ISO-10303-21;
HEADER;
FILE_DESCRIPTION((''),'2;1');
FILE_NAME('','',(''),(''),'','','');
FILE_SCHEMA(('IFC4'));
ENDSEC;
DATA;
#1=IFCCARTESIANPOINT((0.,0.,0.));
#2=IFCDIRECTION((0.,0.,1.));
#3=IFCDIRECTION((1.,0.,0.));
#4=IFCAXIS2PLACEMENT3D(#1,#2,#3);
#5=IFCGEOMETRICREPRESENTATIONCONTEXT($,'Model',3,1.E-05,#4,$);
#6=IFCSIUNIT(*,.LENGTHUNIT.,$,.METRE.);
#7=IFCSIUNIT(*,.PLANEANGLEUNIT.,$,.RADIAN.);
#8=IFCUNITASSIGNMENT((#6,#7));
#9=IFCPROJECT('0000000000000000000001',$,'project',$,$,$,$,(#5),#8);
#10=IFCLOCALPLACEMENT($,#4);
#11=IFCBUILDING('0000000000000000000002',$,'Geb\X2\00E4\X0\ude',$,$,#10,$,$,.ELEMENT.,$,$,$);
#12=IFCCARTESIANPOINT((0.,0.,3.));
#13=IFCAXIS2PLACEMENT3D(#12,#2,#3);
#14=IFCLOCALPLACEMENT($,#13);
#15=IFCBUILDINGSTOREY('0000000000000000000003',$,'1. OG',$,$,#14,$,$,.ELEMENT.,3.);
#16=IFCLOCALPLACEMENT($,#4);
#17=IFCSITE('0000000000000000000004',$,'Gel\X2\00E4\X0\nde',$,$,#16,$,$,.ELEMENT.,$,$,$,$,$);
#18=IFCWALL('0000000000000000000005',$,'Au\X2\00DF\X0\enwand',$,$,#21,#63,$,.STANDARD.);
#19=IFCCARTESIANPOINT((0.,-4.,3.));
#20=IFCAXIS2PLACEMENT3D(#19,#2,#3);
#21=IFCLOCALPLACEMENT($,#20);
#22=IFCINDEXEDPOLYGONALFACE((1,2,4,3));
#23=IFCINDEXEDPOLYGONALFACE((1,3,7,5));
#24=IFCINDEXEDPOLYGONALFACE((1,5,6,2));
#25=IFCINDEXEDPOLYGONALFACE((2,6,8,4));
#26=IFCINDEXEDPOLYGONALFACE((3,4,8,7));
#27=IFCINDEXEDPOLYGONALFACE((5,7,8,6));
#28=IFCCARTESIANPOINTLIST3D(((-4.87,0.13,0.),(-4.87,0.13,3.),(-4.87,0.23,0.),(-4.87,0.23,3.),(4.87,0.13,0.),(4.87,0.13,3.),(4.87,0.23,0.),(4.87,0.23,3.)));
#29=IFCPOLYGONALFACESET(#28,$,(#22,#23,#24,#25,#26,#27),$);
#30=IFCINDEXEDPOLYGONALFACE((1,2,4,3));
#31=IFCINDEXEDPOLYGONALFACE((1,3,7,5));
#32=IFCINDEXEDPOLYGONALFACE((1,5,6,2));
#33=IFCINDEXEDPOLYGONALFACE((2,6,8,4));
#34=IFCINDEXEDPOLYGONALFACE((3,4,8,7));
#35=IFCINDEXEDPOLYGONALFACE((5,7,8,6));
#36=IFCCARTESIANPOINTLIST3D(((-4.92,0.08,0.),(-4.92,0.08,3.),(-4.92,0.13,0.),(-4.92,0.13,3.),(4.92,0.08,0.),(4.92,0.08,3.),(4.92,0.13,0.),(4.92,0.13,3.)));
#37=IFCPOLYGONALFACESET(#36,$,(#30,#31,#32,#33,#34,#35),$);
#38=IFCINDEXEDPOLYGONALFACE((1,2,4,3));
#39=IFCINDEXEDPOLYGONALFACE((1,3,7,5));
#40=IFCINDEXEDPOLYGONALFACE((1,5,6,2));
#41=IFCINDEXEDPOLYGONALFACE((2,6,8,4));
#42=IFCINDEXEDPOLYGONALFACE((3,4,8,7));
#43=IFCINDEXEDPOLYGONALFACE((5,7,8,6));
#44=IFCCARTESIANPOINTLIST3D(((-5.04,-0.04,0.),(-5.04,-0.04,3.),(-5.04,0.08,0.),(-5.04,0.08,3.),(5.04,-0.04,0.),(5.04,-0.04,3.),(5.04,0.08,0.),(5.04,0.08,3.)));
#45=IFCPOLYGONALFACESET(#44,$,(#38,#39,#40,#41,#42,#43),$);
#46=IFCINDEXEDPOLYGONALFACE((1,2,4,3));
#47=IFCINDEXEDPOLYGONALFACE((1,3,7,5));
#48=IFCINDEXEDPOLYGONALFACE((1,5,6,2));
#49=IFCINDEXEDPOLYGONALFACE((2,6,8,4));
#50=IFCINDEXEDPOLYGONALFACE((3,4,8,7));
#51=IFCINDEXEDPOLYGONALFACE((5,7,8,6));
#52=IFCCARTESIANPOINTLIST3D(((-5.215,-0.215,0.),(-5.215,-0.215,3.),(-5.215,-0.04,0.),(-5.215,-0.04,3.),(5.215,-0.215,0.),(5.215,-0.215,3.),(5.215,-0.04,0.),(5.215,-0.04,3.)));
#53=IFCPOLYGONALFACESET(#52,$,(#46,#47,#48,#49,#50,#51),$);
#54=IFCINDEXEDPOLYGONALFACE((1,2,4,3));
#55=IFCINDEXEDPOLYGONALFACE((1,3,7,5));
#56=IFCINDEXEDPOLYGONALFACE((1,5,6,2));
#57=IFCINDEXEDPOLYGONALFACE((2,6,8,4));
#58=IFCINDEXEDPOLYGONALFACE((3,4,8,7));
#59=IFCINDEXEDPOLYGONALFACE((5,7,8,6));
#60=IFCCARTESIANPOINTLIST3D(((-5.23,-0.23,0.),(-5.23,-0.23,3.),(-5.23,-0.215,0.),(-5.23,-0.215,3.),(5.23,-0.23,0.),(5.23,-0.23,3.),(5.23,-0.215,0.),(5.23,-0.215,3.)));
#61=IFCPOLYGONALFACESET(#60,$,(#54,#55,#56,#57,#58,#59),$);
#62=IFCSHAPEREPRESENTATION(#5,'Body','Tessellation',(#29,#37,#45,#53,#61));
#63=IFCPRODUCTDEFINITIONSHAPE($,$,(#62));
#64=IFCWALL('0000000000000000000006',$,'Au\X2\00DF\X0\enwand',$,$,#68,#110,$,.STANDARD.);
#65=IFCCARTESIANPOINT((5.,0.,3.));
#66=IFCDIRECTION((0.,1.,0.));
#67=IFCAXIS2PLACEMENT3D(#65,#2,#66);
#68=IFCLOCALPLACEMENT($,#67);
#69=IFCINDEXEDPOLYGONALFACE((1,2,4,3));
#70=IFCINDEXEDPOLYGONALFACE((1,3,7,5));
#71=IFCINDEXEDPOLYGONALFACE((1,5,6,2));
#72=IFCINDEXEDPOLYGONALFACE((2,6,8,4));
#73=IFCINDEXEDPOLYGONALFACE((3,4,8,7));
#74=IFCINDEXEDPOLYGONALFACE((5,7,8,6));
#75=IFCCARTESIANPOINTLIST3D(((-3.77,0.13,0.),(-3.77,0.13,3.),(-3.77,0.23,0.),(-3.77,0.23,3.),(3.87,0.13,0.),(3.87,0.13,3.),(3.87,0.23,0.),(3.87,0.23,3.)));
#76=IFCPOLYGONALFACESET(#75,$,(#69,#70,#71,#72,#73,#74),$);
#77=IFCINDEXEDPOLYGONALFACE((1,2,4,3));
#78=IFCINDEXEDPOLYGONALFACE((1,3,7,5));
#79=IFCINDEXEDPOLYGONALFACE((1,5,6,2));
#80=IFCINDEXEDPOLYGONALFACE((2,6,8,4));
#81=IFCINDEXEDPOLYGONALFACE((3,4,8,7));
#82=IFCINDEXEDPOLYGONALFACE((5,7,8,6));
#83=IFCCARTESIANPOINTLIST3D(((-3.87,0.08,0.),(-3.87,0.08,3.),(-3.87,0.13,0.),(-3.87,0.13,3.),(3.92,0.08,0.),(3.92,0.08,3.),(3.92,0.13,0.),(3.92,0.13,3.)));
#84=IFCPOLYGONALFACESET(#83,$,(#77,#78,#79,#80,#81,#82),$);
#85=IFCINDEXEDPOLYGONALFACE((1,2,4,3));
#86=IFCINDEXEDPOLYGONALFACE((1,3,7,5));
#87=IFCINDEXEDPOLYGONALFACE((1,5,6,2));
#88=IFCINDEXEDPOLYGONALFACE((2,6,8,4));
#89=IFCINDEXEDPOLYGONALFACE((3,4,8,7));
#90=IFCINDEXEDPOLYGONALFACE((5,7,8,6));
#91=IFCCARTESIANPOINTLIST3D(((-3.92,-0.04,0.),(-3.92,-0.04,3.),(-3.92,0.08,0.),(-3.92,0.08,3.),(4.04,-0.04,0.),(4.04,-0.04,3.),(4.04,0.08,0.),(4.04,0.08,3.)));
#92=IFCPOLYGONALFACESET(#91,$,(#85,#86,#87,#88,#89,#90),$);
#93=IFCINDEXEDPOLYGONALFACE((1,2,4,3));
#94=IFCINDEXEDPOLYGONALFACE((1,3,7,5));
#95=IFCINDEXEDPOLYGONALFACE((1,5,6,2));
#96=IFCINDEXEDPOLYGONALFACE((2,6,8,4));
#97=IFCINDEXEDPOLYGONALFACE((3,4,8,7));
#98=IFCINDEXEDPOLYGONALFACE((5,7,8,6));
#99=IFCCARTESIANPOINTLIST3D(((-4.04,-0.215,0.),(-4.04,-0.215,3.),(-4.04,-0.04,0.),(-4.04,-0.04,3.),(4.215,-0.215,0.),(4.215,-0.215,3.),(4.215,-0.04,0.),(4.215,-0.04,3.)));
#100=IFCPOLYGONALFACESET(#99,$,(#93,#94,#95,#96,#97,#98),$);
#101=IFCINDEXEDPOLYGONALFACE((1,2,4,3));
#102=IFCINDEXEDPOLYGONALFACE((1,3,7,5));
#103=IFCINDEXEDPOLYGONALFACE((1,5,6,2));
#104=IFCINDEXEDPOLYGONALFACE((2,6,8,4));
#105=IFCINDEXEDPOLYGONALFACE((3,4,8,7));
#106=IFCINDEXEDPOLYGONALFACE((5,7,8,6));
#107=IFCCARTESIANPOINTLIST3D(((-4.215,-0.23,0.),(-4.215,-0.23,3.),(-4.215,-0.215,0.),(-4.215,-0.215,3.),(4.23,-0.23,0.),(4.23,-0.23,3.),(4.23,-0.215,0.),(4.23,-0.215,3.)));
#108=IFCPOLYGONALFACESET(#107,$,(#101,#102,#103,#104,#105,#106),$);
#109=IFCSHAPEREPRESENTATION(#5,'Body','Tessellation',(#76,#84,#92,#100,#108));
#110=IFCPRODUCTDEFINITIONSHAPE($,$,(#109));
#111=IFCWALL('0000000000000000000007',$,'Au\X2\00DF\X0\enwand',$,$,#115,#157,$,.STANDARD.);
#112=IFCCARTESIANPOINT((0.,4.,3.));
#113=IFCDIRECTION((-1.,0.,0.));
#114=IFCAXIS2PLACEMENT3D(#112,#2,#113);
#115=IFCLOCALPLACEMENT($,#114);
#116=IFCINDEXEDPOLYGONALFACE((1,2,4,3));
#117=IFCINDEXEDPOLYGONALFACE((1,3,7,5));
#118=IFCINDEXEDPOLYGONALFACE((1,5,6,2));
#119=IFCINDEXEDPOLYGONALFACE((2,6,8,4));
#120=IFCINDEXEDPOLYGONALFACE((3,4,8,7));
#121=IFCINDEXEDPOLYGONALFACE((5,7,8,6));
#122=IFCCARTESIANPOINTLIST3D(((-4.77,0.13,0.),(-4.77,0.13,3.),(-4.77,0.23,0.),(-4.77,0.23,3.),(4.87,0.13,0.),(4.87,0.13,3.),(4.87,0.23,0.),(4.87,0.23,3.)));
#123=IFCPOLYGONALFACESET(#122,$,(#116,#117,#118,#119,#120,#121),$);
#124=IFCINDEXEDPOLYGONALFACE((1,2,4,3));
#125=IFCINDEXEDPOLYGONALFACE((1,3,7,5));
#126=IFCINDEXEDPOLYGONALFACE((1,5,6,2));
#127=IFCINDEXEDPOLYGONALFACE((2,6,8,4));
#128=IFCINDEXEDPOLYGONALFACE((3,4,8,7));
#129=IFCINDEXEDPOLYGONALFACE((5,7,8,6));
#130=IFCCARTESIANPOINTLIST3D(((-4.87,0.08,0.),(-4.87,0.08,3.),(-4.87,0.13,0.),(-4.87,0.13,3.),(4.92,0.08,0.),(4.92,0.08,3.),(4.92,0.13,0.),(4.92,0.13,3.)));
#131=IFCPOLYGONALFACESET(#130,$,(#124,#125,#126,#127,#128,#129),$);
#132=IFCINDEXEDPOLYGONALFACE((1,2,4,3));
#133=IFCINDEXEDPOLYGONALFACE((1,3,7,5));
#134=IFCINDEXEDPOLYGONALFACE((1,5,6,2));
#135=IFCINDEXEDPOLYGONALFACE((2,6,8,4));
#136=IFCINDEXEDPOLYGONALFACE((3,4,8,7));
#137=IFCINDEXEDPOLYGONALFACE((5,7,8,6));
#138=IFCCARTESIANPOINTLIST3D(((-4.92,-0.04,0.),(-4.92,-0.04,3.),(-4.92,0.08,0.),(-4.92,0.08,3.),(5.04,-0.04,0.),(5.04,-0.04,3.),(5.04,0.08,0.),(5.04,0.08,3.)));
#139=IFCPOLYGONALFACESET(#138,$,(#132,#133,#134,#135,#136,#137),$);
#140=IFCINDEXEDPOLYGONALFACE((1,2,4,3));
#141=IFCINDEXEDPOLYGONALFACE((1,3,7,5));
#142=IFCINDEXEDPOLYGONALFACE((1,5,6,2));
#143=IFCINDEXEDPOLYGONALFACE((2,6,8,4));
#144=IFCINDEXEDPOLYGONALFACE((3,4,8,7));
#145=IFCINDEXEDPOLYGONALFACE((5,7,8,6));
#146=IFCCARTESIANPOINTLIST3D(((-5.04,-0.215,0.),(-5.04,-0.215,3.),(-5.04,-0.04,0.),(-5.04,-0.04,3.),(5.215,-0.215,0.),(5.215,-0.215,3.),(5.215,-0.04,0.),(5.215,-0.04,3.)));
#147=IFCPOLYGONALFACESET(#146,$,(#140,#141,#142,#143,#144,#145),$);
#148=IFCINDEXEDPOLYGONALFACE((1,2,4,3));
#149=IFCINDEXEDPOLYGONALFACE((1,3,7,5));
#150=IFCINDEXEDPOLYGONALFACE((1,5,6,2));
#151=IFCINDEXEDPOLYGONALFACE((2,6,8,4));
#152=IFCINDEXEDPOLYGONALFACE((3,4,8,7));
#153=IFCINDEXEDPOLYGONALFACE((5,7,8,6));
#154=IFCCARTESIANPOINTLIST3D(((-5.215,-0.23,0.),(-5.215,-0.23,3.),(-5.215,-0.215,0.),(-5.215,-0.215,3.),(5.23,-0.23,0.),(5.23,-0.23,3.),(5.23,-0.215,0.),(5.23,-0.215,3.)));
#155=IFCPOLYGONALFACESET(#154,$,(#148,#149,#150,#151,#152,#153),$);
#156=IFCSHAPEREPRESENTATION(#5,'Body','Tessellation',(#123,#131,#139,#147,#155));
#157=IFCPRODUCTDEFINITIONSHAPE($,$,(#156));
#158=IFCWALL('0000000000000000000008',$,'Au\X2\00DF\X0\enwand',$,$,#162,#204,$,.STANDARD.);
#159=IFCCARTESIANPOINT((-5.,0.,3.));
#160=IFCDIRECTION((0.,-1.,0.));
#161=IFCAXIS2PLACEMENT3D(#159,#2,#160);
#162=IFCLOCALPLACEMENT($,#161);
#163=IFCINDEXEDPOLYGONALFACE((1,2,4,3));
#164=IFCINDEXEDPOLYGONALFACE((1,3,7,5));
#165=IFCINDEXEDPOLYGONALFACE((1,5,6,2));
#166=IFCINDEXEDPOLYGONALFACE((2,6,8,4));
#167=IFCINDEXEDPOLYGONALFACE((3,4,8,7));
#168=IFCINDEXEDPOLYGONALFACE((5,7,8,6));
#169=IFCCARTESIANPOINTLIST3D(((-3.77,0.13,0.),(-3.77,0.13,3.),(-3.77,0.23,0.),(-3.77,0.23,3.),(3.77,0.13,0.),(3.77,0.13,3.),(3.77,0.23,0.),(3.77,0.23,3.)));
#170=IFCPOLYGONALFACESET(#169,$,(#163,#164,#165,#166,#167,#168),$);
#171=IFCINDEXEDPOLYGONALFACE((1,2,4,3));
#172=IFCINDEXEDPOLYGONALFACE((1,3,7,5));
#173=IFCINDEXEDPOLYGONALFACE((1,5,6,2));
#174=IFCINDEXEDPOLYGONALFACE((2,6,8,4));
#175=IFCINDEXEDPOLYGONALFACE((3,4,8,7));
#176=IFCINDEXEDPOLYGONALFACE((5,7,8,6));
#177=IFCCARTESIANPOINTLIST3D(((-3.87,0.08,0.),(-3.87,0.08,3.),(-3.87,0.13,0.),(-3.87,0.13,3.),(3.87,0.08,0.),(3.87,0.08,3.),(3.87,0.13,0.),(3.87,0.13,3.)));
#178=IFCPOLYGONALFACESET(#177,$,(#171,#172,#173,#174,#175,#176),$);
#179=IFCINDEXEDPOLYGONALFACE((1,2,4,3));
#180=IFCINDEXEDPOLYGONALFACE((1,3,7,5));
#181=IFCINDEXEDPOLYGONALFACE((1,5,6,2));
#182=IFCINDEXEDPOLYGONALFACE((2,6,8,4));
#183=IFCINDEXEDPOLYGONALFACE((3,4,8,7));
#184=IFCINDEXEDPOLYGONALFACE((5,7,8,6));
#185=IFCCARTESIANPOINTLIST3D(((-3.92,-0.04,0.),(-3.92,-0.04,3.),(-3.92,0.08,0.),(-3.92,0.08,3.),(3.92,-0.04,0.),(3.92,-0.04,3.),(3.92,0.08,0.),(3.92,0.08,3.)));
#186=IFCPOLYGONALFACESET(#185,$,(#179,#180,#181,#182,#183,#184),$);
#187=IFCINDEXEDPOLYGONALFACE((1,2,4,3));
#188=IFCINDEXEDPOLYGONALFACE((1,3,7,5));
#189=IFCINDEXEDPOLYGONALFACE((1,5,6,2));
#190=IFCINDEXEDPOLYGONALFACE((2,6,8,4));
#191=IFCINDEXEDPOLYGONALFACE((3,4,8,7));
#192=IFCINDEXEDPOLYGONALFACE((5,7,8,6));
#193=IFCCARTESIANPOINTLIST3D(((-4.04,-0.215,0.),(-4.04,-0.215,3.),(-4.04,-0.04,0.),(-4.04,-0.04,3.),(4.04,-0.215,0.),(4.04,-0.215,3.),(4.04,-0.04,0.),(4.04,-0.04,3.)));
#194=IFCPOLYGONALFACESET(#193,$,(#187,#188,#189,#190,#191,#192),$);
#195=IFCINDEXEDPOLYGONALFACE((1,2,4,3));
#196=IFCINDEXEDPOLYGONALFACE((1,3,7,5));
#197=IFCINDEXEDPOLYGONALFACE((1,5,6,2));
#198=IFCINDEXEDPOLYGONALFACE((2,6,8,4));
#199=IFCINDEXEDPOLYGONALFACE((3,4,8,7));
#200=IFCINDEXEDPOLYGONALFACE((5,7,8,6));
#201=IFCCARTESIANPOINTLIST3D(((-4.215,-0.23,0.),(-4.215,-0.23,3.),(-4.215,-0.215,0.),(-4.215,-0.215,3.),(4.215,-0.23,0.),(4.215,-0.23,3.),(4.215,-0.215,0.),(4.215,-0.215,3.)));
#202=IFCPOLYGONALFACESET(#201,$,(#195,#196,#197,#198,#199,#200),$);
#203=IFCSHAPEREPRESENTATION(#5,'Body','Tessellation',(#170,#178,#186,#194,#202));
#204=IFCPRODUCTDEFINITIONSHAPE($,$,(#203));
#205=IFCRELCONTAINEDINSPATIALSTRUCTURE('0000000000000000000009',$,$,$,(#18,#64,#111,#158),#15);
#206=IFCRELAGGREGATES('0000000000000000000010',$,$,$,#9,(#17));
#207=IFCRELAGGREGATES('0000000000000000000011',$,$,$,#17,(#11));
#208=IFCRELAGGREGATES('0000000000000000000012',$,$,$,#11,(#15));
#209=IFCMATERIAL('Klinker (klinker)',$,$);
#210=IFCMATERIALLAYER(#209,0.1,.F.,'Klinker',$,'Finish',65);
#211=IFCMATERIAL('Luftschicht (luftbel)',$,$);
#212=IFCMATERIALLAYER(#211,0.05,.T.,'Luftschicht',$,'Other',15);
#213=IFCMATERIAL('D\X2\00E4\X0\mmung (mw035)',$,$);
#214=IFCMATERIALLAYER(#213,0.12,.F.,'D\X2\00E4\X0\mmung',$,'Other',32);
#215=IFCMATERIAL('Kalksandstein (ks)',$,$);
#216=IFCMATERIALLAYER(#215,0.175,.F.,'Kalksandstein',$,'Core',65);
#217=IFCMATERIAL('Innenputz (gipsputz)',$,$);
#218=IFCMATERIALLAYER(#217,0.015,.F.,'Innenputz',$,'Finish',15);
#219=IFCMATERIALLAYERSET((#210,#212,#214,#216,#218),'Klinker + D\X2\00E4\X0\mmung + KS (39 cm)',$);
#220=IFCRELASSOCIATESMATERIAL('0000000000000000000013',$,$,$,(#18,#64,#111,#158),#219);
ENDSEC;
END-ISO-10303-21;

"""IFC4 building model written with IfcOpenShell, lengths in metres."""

from ifc_helpers import new_model, si_unit, frame, origin_with_axes, place, context, project, spatial, polyline, outline, extrude, material, layer, layer_set, layer_usage, element, save


model = new_model("IFC4")

# Units and contexts
model_context = context("Model", 3, precision=1e-05, world=origin_with_axes())
ifc_project = project(units=[si_unit("LENGTHUNIT", "METRE"), si_unit("PLANEANGLEUNIT", "RADIAN")], contexts=[model_context])

# Site, building, storey
site_placement = place(None, origin_with_axes())
site = spatial("IfcSite", under=ifc_project, at=site_placement, Name="Gelände", CompositionType="ELEMENT")
building_placement = place(None, origin_with_axes())
building = spatial("IfcBuilding", under=site, at=building_placement, Name="Gebäude", CompositionType="ELEMENT")
storey_placement = place(None, frame((0.0, 0.0, 3.0), z_axis=(0.0, 0.0, 1.0), x_axis=(1.0, 0.0, 0.0)))
storey = spatial("IfcBuildingStorey", under=building, at=storey_placement, Name="1. OG", CompositionType="ELEMENT", Elevation=3.0)

# Walls
ifc_material_1 = material(Name="Klinker (klinker)")
ifc_layer_1 = layer(ifc_material_1, 0.1, ventilated=False, Name="Klinker", Category="Finish", Priority=65)
ifc_material_2 = material(Name="Luftschicht (luftbel)")
ifc_layer_2 = layer(ifc_material_2, 0.05, ventilated=True, Name="Luftschicht", Category="Other", Priority=15)
ifc_material_3 = material(Name="Dämmung (mw035)")
ifc_layer_3 = layer(ifc_material_3, 0.12, ventilated=False, Name="Dämmung", Category="Other", Priority=32)
ifc_material_4 = material(Name="Kalksandstein (ks)")
ifc_layer_4 = layer(ifc_material_4, 0.175, ventilated=False, Name="Kalksandstein", Category="Core", Priority=65)
ifc_material_5 = material(Name="Innenputz (gipsputz)")
ifc_layer_5 = layer(ifc_material_5, 0.015, ventilated=False, Name="Innenputz", Category="Finish", Priority=15)
ifc_layer_set_1 = layer_set([ifc_layer_1, ifc_layer_2, ifc_layer_3, ifc_layer_4, ifc_layer_5], Name="Klinker + Dämmung + KS (39 cm)")
ifc_layer_usage_1 = layer_usage(ifc_layer_set_1, "AXIS2", "NEGATIVE", 0.23)
wall_1_placement = place(None, frame((0.0, -4.0, 3.0), z_axis=(0.0, 0.0, 1.0), x_axis=(1.0, 0.0, 0.0)))
element("IfcWall", 1, at=wall_1_placement, inside=storey, material=ifc_layer_usage_1, Name="Außenwand", PredefinedType="STANDARD", context=model_context, shape_type="SweptSolid", body=[
    extrude(outline(polyline([(-4.87, 0.13), (4.87, 0.13), (4.87, 0.23), (-4.87, 0.23), (-4.87, 0.13)])), origin_with_axes(), (0.0, 0.0, 1.0), 3.0),
    extrude(outline(polyline([(-4.92, 0.08), (4.92, 0.08), (4.92, 0.13), (-4.92, 0.13), (-4.92, 0.08)])), origin_with_axes(), (0.0, 0.0, 1.0), 3.0),
    extrude(outline(polyline([(-5.04, -0.04), (5.04, -0.04), (5.04, 0.08), (-5.04, 0.08), (-5.04, -0.04)])), origin_with_axes(), (0.0, 0.0, 1.0), 3.0),
    extrude(outline(polyline([(-5.215, -0.215), (5.215, -0.215), (5.215, -0.04), (-5.215, -0.04), (-5.215, -0.215)])), origin_with_axes(), (0.0, 0.0, 1.0), 3.0),
    extrude(outline(polyline([(-5.23, -0.23), (5.23, -0.23), (5.23, -0.215), (-5.23, -0.215), (-5.23, -0.23)])), origin_with_axes(), (0.0, 0.0, 1.0), 3.0),
])
ifc_layer_usage_2 = layer_usage(ifc_layer_set_1, "AXIS2", "NEGATIVE", 0.23)
wall_2_placement = place(None, frame((5.0, 0.0, 3.0), z_axis=(0.0, 0.0, 1.0), x_axis=(0.0, 1.0, 0.0)))
element("IfcWall", 2, at=wall_2_placement, inside=storey, material=ifc_layer_usage_2, Name="Außenwand", PredefinedType="STANDARD", context=model_context, shape_type="SweptSolid", body=[
    extrude(outline(polyline([(-3.77, 0.13), (3.87, 0.13), (3.87, 0.23), (-3.77, 0.23), (-3.77, 0.13)])), origin_with_axes(), (0.0, 0.0, 1.0), 3.0),
    extrude(outline(polyline([(-3.87, 0.08), (3.92, 0.08), (3.92, 0.13), (-3.87, 0.13), (-3.87, 0.08)])), origin_with_axes(), (0.0, 0.0, 1.0), 3.0),
    extrude(outline(polyline([(-3.92, -0.04), (4.04, -0.04), (4.04, 0.08), (-3.92, 0.08), (-3.92, -0.04)])), origin_with_axes(), (0.0, 0.0, 1.0), 3.0),
    extrude(outline(polyline([(-4.04, -0.215), (4.215, -0.215), (4.215, -0.04), (-4.04, -0.04), (-4.04, -0.215)])), origin_with_axes(), (0.0, 0.0, 1.0), 3.0),
    extrude(outline(polyline([(-4.215, -0.23), (4.23, -0.23), (4.23, -0.215), (-4.215, -0.215), (-4.215, -0.23)])), origin_with_axes(), (0.0, 0.0, 1.0), 3.0),
])
ifc_layer_usage_3 = layer_usage(ifc_layer_set_1, "AXIS2", "NEGATIVE", 0.23)
wall_3_placement = place(None, frame((0.0, 4.0, 3.0), z_axis=(0.0, 0.0, 1.0), x_axis=(-1.0, 0.0, 0.0)))
element("IfcWall", 3, at=wall_3_placement, inside=storey, material=ifc_layer_usage_3, Name="Außenwand", PredefinedType="STANDARD", context=model_context, shape_type="SweptSolid", body=[
    extrude(outline(polyline([(-4.77, 0.13), (4.87, 0.13), (4.87, 0.23), (-4.77, 0.23), (-4.77, 0.13)])), origin_with_axes(), (0.0, 0.0, 1.0), 3.0),
    extrude(outline(polyline([(-4.87, 0.08), (4.92, 0.08), (4.92, 0.13), (-4.87, 0.13), (-4.87, 0.08)])), origin_with_axes(), (0.0, 0.0, 1.0), 3.0),
    extrude(outline(polyline([(-4.92, -0.04), (5.04, -0.04), (5.04, 0.08), (-4.92, 0.08), (-4.92, -0.04)])), origin_with_axes(), (0.0, 0.0, 1.0), 3.0),
    extrude(outline(polyline([(-5.04, -0.215), (5.215, -0.215), (5.215, -0.04), (-5.04, -0.04), (-5.04, -0.215)])), origin_with_axes(), (0.0, 0.0, 1.0), 3.0),
    extrude(outline(polyline([(-5.215, -0.23), (5.23, -0.23), (5.23, -0.215), (-5.215, -0.215), (-5.215, -0.23)])), origin_with_axes(), (0.0, 0.0, 1.0), 3.0),
])
ifc_layer_usage_4 = layer_usage(ifc_layer_set_1, "AXIS2", "NEGATIVE", 0.23)
wall_4_placement = place(None, frame((-5.0, 0.0, 3.0), z_axis=(0.0, 0.0, 1.0), x_axis=(0.0, -1.0, 0.0)))
element("IfcWall", 4, at=wall_4_placement, inside=storey, material=ifc_layer_usage_4, Name="Außenwand", PredefinedType="STANDARD", context=model_context, shape_type="SweptSolid", body=[
    extrude(outline(polyline([(-3.77, 0.13), (3.77, 0.13), (3.77, 0.23), (-3.77, 0.23), (-3.77, 0.13)])), origin_with_axes(), (0.0, 0.0, 1.0), 3.0),
    extrude(outline(polyline([(-3.87, 0.08), (3.87, 0.08), (3.87, 0.13), (-3.87, 0.13), (-3.87, 0.08)])), origin_with_axes(), (0.0, 0.0, 1.0), 3.0),
    extrude(outline(polyline([(-3.92, -0.04), (3.92, -0.04), (3.92, 0.08), (-3.92, 0.08), (-3.92, -0.04)])), origin_with_axes(), (0.0, 0.0, 1.0), 3.0),
    extrude(outline(polyline([(-4.04, -0.215), (4.04, -0.215), (4.04, -0.04), (-4.04, -0.04), (-4.04, -0.215)])), origin_with_axes(), (0.0, 0.0, 1.0), 3.0),
    extrude(outline(polyline([(-4.215, -0.23), (4.215, -0.23), (4.215, -0.215), (-4.215, -0.215), (-4.215, -0.23)])), origin_with_axes(), (0.0, 0.0, 1.0), 3.0),
])

save(model, "model.ifc")
